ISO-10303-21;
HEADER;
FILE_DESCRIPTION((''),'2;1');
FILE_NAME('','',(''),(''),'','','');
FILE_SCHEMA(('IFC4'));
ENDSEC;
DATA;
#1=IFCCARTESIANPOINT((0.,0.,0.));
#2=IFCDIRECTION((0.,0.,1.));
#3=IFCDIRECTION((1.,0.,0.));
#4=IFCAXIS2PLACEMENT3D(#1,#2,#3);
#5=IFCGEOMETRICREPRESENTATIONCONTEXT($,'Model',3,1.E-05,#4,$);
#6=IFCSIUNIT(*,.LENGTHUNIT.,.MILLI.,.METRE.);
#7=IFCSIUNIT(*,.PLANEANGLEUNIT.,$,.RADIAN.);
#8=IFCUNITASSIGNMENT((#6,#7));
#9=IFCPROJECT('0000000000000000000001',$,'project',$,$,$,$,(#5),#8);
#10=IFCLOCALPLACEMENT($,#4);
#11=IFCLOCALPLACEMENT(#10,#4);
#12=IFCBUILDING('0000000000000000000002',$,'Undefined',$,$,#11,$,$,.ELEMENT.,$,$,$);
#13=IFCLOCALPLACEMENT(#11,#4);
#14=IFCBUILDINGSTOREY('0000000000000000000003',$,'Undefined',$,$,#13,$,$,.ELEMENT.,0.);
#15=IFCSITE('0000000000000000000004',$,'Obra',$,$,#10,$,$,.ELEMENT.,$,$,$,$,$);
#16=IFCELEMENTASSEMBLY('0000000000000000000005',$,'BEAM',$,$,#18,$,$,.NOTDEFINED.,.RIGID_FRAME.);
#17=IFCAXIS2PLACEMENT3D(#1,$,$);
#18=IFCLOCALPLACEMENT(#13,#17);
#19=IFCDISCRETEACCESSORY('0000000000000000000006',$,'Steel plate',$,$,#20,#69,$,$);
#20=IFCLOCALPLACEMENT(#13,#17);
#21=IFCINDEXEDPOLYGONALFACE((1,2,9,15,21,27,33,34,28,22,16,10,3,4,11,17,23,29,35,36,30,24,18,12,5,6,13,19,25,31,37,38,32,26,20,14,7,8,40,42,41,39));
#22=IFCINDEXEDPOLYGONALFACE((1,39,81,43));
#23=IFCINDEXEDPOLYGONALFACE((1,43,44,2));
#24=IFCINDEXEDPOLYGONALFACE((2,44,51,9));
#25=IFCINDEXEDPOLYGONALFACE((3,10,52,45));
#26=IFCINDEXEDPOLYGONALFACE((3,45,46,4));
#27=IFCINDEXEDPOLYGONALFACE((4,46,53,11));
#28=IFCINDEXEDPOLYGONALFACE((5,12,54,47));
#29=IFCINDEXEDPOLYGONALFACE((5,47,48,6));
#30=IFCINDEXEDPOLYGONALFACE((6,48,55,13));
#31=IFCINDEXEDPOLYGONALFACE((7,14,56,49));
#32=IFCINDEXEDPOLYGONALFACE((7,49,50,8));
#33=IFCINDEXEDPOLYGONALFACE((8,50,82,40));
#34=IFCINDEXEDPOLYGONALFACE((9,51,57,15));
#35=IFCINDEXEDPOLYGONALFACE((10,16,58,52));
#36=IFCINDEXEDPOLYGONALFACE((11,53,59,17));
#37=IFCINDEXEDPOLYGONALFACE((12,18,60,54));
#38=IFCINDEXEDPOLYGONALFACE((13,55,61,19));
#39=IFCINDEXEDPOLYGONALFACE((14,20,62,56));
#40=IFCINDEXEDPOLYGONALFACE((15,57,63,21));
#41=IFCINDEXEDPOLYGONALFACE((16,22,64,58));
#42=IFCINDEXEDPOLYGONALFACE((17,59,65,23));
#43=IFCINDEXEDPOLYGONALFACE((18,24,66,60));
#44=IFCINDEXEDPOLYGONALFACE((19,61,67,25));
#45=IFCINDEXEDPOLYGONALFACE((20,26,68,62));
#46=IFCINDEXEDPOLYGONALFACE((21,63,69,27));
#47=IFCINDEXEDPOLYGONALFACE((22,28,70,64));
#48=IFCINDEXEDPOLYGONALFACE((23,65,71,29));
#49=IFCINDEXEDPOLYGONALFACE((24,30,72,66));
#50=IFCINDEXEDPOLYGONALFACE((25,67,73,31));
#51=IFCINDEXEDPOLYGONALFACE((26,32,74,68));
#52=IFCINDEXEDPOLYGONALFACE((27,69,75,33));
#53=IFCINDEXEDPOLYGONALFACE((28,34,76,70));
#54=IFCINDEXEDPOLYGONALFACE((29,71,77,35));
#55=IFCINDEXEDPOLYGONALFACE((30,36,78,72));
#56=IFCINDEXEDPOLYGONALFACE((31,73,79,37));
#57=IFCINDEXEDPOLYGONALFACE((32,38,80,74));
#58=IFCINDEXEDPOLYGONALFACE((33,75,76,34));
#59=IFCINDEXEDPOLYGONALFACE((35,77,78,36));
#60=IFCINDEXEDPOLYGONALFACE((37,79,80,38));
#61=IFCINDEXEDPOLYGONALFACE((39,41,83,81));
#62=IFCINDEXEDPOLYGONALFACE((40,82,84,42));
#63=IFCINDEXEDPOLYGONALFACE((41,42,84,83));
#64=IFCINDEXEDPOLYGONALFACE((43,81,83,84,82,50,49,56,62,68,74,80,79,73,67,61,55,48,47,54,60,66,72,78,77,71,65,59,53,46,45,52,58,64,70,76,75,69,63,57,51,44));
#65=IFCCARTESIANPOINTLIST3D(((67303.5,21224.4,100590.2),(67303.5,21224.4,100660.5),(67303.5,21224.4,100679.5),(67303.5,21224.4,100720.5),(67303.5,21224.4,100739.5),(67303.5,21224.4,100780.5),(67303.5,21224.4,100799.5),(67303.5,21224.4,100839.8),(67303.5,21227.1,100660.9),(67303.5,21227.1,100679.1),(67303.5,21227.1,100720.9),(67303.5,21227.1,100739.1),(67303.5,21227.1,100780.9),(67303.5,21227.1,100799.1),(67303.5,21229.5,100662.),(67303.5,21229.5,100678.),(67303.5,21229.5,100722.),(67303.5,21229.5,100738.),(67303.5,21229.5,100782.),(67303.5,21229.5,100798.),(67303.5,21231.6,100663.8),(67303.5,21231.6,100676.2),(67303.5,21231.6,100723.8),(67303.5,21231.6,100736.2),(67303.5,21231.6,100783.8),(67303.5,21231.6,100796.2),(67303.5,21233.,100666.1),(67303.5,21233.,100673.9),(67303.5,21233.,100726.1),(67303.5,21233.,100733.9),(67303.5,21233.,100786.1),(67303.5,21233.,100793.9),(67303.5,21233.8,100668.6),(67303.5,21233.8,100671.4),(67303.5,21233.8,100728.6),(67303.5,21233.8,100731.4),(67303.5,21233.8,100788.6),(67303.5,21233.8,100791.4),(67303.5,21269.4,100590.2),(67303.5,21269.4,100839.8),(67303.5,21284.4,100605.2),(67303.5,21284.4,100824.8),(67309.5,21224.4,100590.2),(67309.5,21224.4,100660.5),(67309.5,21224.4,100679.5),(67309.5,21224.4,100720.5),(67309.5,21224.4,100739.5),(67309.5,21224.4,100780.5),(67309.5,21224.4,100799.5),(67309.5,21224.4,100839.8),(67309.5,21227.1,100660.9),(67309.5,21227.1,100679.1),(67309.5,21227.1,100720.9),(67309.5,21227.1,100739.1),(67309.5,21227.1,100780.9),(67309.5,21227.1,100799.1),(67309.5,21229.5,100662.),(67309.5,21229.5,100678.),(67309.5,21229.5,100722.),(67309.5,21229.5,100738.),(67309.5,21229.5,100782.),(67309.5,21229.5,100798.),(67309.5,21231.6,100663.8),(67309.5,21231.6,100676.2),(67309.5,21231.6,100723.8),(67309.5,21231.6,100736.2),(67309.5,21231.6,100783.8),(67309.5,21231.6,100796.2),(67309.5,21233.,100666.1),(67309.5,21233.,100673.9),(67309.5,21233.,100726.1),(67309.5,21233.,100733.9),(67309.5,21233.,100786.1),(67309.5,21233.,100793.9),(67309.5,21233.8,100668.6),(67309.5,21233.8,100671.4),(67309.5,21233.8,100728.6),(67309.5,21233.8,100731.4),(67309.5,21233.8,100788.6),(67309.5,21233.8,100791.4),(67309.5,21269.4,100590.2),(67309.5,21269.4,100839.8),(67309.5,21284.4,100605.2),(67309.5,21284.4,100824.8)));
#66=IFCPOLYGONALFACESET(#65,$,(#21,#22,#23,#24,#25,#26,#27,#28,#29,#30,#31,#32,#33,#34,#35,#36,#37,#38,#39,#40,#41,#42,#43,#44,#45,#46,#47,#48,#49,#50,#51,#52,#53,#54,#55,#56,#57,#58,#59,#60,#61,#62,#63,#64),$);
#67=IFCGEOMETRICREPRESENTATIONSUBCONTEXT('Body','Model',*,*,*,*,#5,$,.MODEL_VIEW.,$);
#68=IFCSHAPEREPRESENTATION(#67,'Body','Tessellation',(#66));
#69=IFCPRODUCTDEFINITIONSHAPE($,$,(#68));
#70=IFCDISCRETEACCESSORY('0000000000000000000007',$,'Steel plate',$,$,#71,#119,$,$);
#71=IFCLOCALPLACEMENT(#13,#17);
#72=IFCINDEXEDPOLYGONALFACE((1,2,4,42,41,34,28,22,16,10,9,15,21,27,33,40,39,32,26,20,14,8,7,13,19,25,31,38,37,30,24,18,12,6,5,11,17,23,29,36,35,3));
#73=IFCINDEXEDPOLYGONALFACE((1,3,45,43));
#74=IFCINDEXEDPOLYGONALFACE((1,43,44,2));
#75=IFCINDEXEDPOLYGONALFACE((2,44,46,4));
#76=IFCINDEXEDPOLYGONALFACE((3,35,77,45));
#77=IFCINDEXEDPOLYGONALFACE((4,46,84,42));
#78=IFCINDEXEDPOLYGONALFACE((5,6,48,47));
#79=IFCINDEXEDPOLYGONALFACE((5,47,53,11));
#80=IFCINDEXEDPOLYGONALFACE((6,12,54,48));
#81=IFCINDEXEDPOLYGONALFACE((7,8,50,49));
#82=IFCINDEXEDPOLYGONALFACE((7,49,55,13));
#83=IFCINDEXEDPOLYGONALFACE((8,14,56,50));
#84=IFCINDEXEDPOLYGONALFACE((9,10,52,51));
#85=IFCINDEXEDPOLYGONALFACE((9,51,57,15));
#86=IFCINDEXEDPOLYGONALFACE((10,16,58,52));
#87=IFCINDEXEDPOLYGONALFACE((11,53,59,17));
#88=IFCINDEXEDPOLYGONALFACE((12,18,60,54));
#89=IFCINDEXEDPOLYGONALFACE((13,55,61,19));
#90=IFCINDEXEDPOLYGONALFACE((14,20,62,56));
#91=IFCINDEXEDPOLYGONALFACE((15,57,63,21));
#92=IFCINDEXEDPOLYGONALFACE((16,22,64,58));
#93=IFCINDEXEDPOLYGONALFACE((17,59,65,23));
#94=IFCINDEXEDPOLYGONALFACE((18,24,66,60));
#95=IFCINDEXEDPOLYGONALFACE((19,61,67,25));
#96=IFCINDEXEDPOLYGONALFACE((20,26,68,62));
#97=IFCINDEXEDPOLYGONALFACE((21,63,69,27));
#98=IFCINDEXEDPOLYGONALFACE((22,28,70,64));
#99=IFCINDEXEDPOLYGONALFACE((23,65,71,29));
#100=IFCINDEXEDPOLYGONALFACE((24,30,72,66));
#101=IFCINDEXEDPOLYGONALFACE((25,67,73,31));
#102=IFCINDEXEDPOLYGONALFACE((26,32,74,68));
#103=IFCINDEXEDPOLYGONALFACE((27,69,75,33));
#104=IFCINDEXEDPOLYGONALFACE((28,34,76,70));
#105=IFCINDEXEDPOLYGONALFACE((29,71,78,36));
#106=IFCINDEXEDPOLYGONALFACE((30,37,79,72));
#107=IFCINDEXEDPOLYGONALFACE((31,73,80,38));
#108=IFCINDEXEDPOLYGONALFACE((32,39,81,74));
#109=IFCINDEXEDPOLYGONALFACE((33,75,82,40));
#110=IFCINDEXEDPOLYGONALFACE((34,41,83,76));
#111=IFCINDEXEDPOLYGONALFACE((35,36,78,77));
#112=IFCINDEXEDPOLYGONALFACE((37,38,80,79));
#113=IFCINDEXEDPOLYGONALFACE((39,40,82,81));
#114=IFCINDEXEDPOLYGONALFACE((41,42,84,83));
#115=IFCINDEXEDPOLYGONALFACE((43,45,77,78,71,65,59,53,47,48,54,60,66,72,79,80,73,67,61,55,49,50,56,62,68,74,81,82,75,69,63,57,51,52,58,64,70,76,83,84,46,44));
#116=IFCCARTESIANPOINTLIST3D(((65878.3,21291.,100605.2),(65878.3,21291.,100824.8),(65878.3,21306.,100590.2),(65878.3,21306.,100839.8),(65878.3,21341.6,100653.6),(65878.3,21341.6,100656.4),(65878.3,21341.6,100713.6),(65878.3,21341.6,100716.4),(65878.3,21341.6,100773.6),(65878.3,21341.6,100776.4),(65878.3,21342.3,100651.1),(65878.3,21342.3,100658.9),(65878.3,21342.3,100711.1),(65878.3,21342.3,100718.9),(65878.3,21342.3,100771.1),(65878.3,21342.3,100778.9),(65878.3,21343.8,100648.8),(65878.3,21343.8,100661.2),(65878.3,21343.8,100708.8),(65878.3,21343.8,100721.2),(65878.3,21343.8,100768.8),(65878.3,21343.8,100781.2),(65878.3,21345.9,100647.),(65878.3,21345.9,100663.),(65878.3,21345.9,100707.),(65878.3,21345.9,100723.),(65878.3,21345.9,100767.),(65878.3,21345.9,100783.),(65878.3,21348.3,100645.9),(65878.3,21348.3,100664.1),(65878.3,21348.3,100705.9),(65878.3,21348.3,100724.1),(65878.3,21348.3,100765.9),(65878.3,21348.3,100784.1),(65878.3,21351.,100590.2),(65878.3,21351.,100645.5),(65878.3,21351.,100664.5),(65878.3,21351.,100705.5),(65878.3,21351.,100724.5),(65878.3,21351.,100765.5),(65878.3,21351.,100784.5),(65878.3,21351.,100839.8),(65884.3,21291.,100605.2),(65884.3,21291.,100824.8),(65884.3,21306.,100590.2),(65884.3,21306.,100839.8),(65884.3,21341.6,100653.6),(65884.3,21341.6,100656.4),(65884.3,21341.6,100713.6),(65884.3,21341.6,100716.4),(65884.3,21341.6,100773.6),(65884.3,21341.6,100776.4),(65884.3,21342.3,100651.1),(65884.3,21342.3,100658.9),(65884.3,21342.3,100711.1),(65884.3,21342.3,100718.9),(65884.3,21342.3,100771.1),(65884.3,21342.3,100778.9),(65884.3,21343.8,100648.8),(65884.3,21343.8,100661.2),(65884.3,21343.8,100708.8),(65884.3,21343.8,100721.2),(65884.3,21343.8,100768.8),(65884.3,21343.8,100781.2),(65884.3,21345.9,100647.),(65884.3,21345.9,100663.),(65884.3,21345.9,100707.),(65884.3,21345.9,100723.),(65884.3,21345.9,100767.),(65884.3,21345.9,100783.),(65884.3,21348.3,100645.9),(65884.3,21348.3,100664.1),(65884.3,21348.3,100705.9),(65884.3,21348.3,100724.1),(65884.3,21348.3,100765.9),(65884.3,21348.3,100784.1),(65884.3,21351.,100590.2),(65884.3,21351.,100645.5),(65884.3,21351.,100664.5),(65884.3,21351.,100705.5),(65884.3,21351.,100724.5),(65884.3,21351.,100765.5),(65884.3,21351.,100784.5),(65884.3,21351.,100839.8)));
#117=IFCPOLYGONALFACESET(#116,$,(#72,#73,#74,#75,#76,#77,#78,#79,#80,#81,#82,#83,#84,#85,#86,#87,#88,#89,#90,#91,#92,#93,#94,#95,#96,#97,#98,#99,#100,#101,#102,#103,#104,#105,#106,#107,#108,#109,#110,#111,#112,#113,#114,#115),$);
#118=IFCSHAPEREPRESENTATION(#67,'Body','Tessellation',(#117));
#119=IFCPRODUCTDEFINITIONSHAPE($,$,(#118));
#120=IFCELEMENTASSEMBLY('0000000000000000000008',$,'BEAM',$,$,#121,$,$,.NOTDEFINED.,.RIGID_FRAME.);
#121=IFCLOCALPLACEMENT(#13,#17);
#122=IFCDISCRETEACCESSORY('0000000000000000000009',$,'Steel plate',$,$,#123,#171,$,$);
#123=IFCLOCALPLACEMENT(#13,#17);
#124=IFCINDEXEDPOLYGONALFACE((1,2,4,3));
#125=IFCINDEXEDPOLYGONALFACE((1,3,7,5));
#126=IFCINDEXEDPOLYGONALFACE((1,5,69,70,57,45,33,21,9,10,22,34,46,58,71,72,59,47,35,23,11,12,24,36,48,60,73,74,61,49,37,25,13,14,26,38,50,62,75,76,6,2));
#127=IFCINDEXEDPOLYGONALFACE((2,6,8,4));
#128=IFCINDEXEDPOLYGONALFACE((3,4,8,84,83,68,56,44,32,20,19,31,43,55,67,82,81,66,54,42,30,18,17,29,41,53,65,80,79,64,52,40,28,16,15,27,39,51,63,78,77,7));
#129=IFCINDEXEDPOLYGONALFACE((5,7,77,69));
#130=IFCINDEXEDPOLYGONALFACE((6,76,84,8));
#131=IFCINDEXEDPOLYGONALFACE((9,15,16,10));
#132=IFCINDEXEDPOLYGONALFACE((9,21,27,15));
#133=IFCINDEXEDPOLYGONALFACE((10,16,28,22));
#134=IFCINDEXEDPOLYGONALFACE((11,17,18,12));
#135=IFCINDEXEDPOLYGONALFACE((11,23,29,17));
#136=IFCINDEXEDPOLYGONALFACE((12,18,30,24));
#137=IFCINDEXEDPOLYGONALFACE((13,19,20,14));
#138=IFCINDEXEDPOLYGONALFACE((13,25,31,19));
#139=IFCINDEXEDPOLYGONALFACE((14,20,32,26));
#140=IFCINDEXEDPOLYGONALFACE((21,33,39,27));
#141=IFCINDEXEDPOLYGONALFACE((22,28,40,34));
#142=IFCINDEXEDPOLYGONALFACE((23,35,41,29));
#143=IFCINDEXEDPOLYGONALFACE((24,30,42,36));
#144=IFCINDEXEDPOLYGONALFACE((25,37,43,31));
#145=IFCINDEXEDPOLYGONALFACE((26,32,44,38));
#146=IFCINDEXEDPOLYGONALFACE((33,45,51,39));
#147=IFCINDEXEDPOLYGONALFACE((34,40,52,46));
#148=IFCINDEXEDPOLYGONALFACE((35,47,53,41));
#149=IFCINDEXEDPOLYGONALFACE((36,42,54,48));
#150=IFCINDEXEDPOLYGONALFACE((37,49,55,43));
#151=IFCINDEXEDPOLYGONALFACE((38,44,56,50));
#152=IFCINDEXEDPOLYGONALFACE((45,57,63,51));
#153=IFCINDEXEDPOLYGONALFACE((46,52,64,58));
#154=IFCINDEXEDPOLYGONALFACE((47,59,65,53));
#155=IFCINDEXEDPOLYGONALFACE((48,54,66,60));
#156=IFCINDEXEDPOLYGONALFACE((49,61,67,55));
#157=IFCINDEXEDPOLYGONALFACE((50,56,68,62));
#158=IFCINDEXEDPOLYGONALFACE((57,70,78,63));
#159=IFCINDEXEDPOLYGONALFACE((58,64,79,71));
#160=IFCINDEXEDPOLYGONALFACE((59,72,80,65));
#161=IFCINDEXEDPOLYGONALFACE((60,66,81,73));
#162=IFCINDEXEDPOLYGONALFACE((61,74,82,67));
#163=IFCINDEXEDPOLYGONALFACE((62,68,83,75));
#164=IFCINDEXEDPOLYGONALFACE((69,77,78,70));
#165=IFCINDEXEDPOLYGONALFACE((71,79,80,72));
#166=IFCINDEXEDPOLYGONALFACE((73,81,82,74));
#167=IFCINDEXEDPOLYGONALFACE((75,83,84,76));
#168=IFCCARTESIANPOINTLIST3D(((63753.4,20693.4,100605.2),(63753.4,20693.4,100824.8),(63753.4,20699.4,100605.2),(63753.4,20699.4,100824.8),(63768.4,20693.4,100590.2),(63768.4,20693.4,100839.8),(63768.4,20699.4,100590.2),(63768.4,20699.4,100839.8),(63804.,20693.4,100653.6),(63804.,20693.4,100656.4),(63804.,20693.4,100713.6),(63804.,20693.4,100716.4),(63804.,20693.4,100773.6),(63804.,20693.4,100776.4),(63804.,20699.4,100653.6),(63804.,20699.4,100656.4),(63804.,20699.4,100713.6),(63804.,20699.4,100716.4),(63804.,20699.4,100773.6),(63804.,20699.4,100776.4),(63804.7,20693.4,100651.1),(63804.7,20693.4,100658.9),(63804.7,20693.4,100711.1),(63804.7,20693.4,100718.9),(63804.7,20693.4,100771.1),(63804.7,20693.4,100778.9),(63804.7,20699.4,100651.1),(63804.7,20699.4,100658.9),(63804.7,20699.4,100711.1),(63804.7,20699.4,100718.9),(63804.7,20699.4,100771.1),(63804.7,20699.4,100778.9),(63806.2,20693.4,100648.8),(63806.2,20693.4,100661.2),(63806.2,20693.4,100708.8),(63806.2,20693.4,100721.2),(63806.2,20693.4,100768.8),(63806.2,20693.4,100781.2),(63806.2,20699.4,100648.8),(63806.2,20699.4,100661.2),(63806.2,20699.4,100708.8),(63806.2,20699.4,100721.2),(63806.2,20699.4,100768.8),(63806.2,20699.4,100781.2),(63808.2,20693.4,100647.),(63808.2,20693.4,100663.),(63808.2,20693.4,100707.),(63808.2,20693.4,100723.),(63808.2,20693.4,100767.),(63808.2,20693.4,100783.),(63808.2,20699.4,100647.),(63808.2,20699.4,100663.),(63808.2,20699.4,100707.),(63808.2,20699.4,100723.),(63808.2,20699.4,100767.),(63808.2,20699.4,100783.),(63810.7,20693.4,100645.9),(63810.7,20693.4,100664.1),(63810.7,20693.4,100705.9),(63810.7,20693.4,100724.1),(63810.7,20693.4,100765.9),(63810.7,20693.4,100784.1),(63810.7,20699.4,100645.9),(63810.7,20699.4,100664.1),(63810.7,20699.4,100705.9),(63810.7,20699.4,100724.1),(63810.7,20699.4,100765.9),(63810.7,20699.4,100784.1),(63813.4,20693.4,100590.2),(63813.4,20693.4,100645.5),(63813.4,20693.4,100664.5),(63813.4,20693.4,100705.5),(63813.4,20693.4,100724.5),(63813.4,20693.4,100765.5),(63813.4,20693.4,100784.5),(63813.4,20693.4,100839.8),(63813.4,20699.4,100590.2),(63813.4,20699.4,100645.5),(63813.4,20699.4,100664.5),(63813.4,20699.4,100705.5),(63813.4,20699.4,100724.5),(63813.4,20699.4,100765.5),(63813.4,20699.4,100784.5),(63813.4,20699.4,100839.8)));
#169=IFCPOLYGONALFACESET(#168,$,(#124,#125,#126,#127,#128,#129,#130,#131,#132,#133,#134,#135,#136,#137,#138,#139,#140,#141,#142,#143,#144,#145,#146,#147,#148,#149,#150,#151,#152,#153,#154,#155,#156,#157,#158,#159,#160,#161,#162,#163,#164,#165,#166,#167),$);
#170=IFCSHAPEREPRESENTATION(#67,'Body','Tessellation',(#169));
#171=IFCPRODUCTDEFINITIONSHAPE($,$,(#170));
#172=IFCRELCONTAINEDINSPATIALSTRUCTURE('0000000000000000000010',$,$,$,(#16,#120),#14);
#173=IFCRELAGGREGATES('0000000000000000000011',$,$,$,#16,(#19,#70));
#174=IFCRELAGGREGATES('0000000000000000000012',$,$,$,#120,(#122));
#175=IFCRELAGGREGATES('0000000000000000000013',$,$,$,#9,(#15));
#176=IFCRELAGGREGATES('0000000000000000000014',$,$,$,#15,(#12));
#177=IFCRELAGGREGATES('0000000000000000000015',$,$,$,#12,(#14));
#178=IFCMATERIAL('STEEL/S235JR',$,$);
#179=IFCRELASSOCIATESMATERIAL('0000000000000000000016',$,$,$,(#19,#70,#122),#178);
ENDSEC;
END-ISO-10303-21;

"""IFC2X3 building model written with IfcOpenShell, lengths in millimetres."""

from ifc_helpers import new_model, si_unit, frame, origin_with_axes, origin_2d_with_axis, place, context, subcontext, project, spatial, polyline, circle, outline, extrude, source, transform, mapped, material, element, aggregate, save


model = new_model("IFC2X3")

# Units and contexts
model_context = context("Model", 3, precision=1e-05, world=origin_with_axes())
body_context = subcontext(model_context, "Body", "Model", "MODEL_VIEW")
ifc_project = project(units=[si_unit("LENGTHUNIT", "METRE", prefix="MILLI"), si_unit("PLANEANGLEUNIT", "RADIAN")], contexts=[model_context])

# Site, building, storey
site_placement = place(None, origin_with_axes())
site = spatial("IfcSite", under=ifc_project, at=site_placement, Name="Obra", CompositionType="ELEMENT")
building_placement = place(site_placement, origin_with_axes())
building = spatial("IfcBuilding", under=site, at=building_placement, Name="Undefined", CompositionType="ELEMENT")
storey_placement = place(building_placement, origin_with_axes())
storey = spatial("IfcBuildingStorey", under=building, at=storey_placement, Name="Undefined", CompositionType="ELEMENT", Elevation=0.0)

# Shared definitions
ifc_material = material(Name="STEEL/S235JR")

# Element assemblies, discrete accessories, openings
shared_shape_1 = source(origin_with_axes(), body_context, "Body", "SweptSolid", [
    extrude(circle(Radius=9.5, at=origin_2d_with_axis()), frame((0.0, -9.4, 0.0), z_axis=(0.0, 1.0, 0.0), x_axis=(1.0, 0.0, 0.0)), (0.0, 0.0, 1.0), 6.2),
])
shared_shape_2 = source(origin_with_axes(), body_context, "Body", "SweptSolid", [
    extrude(circle(Radius=9.5, at=origin_2d_with_axis()), frame((0.0, -9.2, 0.0), z_axis=(0.0, 1.0, 0.0), x_axis=(1.0, 0.0, 0.0)), (0.0, 0.0, 1.0), 6.2),
])
assembly_1_placement = place(storey_placement, origin_with_axes())
assembly_1 = element("IfcElementAssembly", 1, at=assembly_1_placement, inside=storey, Name="BEAM", AssemblyPlace="NOTDEFINED", PredefinedType="RIGID_FRAME")
discrete_accessory_1_placement = place(assembly_1_placement, frame((67306.5, 21224.4, 100590.2), z_axis=(1.0, 0.000001, 0.0), x_axis=(-0.000002, 1.0, 0.0)))
discrete_accessory_1 = element("IfcDiscreteAccessory", 2, at=discrete_accessory_1_placement, material=ifc_material, Name="Steel plate", context=body_context, shape_type="SweptSolid", body=[
    extrude(outline(polyline([(0.0, 0.0), (45.0, 0.0), (60.0, 15.0), (60.0, 234.6), (45.0, 249.6), (0.0, 249.6), (0.0, 0.0)])), frame((0.0, 0.0, -3.0), z_axis=(0.0, 0.0, 1.0), x_axis=(1.0, 0.0, 0.0)), (0.0, 0.0, 1.0), 6.0),
])
opening_1_placement = place(assembly_1_placement, frame((67312.6, 21274.4, 100850.0), z_axis=(0.000002, -1.0, 0.0), x_axis=(0.0, 0.0, -1.0)))
element("IfcOpeningElement", 3, at=opening_1_placement, cuts=discrete_accessory_1, ObjectType="Opening", context=body_context, shape_type="MappedRepresentation", body=[
    mapped(shared_shape_2, transform((60.0, 0.0, 50.0))),
    mapped(shared_shape_2, transform((120.0, 0.0, 50.0))),
    mapped(shared_shape_2, transform((180.0, 0.0, 50.0))),
])
discrete_accessory_2_placement = place(assembly_1_placement, frame((65881.3, 21351.0, 100590.2), z_axis=(-1.0, -0.000002, 0.0), x_axis=(0.000002, -1.0, 0.0)))
discrete_accessory_2 = element("IfcDiscreteAccessory", 4, at=discrete_accessory_2_placement, material=ifc_material, Name="Steel plate", context=body_context, shape_type="SweptSolid", body=[
    extrude(outline(polyline([(0.0, 0.0), (45.0, 0.0), (60.0, 15.0), (60.0, 234.6), (45.0, 249.6), (0.0, 249.6), (0.0, 0.0)])), frame((0.0, 0.0, -3.0), z_axis=(0.0, 0.0, 1.0), x_axis=(1.0, 0.0, 0.0)), (0.0, 0.0, 1.0), 6.0),
])
opening_2_placement = place(assembly_1_placement, frame((65875.0, 21301.0, 100850.0), z_axis=(-0.000002, 1.0, 0.0), x_axis=(0.0, 0.0, -1.0)))
element("IfcOpeningElement", 5, at=opening_2_placement, cuts=discrete_accessory_2, ObjectType="Opening", context=body_context, shape_type="MappedRepresentation", body=[
    mapped(shared_shape_1, transform((75.0, 0.0, 50.0))),
    mapped(shared_shape_1, transform((135.0, 0.0, 50.0))),
    mapped(shared_shape_1, transform((195.0, 0.0, 50.0))),
])
aggregate(assembly_1, [discrete_accessory_1, discrete_accessory_2])
assembly_2_placement = place(storey_placement, origin_with_axes())
assembly_2 = element("IfcElementAssembly", 6, at=assembly_2_placement, inside=storey, Name="BEAM", AssemblyPlace="NOTDEFINED", PredefinedType="RIGID_FRAME")
discrete_accessory_3_placement = place(assembly_2_placement, frame((63813.4, 20696.4, 100590.2), z_axis=(0.0, 1.0, 0.0), x_axis=(-1.0, 0.0, 0.0)))
discrete_accessory_3 = element("IfcDiscreteAccessory", 7, at=discrete_accessory_3_placement, material=ifc_material, Name="Steel plate", context=body_context, shape_type="SweptSolid", body=[
    extrude(outline(polyline([(0.0, 0.0), (45.0, 0.0), (60.0, 15.0), (60.0, 234.6), (45.0, 249.6), (0.0, 249.6), (0.0, 0.0)])), frame((0.0, 0.0, -3.0), z_axis=(0.0, 0.0, 1.0), x_axis=(1.0, 0.0, 0.0)), (0.0, 0.0, 1.0), 6.0),
])
opening_3_placement = place(assembly_2_placement, frame((63763.4, 20702.7, 100850.0), z_axis=(1.0, 0.0, 0.0), x_axis=(0.0, 0.0, -1.0)))
element("IfcOpeningElement", 8, at=opening_3_placement, cuts=discrete_accessory_3, ObjectType="Opening", context=body_context, shape_type="MappedRepresentation", body=[
    mapped(shared_shape_1, transform((75.0, 0.0, 50.0))),
    mapped(shared_shape_1, transform((135.0, 0.0, 50.0))),
    mapped(shared_shape_1, transform((195.0, 0.0, 50.0))),
])
aggregate(assembly_2, [discrete_accessory_3])

save(model, "model.ifc")
